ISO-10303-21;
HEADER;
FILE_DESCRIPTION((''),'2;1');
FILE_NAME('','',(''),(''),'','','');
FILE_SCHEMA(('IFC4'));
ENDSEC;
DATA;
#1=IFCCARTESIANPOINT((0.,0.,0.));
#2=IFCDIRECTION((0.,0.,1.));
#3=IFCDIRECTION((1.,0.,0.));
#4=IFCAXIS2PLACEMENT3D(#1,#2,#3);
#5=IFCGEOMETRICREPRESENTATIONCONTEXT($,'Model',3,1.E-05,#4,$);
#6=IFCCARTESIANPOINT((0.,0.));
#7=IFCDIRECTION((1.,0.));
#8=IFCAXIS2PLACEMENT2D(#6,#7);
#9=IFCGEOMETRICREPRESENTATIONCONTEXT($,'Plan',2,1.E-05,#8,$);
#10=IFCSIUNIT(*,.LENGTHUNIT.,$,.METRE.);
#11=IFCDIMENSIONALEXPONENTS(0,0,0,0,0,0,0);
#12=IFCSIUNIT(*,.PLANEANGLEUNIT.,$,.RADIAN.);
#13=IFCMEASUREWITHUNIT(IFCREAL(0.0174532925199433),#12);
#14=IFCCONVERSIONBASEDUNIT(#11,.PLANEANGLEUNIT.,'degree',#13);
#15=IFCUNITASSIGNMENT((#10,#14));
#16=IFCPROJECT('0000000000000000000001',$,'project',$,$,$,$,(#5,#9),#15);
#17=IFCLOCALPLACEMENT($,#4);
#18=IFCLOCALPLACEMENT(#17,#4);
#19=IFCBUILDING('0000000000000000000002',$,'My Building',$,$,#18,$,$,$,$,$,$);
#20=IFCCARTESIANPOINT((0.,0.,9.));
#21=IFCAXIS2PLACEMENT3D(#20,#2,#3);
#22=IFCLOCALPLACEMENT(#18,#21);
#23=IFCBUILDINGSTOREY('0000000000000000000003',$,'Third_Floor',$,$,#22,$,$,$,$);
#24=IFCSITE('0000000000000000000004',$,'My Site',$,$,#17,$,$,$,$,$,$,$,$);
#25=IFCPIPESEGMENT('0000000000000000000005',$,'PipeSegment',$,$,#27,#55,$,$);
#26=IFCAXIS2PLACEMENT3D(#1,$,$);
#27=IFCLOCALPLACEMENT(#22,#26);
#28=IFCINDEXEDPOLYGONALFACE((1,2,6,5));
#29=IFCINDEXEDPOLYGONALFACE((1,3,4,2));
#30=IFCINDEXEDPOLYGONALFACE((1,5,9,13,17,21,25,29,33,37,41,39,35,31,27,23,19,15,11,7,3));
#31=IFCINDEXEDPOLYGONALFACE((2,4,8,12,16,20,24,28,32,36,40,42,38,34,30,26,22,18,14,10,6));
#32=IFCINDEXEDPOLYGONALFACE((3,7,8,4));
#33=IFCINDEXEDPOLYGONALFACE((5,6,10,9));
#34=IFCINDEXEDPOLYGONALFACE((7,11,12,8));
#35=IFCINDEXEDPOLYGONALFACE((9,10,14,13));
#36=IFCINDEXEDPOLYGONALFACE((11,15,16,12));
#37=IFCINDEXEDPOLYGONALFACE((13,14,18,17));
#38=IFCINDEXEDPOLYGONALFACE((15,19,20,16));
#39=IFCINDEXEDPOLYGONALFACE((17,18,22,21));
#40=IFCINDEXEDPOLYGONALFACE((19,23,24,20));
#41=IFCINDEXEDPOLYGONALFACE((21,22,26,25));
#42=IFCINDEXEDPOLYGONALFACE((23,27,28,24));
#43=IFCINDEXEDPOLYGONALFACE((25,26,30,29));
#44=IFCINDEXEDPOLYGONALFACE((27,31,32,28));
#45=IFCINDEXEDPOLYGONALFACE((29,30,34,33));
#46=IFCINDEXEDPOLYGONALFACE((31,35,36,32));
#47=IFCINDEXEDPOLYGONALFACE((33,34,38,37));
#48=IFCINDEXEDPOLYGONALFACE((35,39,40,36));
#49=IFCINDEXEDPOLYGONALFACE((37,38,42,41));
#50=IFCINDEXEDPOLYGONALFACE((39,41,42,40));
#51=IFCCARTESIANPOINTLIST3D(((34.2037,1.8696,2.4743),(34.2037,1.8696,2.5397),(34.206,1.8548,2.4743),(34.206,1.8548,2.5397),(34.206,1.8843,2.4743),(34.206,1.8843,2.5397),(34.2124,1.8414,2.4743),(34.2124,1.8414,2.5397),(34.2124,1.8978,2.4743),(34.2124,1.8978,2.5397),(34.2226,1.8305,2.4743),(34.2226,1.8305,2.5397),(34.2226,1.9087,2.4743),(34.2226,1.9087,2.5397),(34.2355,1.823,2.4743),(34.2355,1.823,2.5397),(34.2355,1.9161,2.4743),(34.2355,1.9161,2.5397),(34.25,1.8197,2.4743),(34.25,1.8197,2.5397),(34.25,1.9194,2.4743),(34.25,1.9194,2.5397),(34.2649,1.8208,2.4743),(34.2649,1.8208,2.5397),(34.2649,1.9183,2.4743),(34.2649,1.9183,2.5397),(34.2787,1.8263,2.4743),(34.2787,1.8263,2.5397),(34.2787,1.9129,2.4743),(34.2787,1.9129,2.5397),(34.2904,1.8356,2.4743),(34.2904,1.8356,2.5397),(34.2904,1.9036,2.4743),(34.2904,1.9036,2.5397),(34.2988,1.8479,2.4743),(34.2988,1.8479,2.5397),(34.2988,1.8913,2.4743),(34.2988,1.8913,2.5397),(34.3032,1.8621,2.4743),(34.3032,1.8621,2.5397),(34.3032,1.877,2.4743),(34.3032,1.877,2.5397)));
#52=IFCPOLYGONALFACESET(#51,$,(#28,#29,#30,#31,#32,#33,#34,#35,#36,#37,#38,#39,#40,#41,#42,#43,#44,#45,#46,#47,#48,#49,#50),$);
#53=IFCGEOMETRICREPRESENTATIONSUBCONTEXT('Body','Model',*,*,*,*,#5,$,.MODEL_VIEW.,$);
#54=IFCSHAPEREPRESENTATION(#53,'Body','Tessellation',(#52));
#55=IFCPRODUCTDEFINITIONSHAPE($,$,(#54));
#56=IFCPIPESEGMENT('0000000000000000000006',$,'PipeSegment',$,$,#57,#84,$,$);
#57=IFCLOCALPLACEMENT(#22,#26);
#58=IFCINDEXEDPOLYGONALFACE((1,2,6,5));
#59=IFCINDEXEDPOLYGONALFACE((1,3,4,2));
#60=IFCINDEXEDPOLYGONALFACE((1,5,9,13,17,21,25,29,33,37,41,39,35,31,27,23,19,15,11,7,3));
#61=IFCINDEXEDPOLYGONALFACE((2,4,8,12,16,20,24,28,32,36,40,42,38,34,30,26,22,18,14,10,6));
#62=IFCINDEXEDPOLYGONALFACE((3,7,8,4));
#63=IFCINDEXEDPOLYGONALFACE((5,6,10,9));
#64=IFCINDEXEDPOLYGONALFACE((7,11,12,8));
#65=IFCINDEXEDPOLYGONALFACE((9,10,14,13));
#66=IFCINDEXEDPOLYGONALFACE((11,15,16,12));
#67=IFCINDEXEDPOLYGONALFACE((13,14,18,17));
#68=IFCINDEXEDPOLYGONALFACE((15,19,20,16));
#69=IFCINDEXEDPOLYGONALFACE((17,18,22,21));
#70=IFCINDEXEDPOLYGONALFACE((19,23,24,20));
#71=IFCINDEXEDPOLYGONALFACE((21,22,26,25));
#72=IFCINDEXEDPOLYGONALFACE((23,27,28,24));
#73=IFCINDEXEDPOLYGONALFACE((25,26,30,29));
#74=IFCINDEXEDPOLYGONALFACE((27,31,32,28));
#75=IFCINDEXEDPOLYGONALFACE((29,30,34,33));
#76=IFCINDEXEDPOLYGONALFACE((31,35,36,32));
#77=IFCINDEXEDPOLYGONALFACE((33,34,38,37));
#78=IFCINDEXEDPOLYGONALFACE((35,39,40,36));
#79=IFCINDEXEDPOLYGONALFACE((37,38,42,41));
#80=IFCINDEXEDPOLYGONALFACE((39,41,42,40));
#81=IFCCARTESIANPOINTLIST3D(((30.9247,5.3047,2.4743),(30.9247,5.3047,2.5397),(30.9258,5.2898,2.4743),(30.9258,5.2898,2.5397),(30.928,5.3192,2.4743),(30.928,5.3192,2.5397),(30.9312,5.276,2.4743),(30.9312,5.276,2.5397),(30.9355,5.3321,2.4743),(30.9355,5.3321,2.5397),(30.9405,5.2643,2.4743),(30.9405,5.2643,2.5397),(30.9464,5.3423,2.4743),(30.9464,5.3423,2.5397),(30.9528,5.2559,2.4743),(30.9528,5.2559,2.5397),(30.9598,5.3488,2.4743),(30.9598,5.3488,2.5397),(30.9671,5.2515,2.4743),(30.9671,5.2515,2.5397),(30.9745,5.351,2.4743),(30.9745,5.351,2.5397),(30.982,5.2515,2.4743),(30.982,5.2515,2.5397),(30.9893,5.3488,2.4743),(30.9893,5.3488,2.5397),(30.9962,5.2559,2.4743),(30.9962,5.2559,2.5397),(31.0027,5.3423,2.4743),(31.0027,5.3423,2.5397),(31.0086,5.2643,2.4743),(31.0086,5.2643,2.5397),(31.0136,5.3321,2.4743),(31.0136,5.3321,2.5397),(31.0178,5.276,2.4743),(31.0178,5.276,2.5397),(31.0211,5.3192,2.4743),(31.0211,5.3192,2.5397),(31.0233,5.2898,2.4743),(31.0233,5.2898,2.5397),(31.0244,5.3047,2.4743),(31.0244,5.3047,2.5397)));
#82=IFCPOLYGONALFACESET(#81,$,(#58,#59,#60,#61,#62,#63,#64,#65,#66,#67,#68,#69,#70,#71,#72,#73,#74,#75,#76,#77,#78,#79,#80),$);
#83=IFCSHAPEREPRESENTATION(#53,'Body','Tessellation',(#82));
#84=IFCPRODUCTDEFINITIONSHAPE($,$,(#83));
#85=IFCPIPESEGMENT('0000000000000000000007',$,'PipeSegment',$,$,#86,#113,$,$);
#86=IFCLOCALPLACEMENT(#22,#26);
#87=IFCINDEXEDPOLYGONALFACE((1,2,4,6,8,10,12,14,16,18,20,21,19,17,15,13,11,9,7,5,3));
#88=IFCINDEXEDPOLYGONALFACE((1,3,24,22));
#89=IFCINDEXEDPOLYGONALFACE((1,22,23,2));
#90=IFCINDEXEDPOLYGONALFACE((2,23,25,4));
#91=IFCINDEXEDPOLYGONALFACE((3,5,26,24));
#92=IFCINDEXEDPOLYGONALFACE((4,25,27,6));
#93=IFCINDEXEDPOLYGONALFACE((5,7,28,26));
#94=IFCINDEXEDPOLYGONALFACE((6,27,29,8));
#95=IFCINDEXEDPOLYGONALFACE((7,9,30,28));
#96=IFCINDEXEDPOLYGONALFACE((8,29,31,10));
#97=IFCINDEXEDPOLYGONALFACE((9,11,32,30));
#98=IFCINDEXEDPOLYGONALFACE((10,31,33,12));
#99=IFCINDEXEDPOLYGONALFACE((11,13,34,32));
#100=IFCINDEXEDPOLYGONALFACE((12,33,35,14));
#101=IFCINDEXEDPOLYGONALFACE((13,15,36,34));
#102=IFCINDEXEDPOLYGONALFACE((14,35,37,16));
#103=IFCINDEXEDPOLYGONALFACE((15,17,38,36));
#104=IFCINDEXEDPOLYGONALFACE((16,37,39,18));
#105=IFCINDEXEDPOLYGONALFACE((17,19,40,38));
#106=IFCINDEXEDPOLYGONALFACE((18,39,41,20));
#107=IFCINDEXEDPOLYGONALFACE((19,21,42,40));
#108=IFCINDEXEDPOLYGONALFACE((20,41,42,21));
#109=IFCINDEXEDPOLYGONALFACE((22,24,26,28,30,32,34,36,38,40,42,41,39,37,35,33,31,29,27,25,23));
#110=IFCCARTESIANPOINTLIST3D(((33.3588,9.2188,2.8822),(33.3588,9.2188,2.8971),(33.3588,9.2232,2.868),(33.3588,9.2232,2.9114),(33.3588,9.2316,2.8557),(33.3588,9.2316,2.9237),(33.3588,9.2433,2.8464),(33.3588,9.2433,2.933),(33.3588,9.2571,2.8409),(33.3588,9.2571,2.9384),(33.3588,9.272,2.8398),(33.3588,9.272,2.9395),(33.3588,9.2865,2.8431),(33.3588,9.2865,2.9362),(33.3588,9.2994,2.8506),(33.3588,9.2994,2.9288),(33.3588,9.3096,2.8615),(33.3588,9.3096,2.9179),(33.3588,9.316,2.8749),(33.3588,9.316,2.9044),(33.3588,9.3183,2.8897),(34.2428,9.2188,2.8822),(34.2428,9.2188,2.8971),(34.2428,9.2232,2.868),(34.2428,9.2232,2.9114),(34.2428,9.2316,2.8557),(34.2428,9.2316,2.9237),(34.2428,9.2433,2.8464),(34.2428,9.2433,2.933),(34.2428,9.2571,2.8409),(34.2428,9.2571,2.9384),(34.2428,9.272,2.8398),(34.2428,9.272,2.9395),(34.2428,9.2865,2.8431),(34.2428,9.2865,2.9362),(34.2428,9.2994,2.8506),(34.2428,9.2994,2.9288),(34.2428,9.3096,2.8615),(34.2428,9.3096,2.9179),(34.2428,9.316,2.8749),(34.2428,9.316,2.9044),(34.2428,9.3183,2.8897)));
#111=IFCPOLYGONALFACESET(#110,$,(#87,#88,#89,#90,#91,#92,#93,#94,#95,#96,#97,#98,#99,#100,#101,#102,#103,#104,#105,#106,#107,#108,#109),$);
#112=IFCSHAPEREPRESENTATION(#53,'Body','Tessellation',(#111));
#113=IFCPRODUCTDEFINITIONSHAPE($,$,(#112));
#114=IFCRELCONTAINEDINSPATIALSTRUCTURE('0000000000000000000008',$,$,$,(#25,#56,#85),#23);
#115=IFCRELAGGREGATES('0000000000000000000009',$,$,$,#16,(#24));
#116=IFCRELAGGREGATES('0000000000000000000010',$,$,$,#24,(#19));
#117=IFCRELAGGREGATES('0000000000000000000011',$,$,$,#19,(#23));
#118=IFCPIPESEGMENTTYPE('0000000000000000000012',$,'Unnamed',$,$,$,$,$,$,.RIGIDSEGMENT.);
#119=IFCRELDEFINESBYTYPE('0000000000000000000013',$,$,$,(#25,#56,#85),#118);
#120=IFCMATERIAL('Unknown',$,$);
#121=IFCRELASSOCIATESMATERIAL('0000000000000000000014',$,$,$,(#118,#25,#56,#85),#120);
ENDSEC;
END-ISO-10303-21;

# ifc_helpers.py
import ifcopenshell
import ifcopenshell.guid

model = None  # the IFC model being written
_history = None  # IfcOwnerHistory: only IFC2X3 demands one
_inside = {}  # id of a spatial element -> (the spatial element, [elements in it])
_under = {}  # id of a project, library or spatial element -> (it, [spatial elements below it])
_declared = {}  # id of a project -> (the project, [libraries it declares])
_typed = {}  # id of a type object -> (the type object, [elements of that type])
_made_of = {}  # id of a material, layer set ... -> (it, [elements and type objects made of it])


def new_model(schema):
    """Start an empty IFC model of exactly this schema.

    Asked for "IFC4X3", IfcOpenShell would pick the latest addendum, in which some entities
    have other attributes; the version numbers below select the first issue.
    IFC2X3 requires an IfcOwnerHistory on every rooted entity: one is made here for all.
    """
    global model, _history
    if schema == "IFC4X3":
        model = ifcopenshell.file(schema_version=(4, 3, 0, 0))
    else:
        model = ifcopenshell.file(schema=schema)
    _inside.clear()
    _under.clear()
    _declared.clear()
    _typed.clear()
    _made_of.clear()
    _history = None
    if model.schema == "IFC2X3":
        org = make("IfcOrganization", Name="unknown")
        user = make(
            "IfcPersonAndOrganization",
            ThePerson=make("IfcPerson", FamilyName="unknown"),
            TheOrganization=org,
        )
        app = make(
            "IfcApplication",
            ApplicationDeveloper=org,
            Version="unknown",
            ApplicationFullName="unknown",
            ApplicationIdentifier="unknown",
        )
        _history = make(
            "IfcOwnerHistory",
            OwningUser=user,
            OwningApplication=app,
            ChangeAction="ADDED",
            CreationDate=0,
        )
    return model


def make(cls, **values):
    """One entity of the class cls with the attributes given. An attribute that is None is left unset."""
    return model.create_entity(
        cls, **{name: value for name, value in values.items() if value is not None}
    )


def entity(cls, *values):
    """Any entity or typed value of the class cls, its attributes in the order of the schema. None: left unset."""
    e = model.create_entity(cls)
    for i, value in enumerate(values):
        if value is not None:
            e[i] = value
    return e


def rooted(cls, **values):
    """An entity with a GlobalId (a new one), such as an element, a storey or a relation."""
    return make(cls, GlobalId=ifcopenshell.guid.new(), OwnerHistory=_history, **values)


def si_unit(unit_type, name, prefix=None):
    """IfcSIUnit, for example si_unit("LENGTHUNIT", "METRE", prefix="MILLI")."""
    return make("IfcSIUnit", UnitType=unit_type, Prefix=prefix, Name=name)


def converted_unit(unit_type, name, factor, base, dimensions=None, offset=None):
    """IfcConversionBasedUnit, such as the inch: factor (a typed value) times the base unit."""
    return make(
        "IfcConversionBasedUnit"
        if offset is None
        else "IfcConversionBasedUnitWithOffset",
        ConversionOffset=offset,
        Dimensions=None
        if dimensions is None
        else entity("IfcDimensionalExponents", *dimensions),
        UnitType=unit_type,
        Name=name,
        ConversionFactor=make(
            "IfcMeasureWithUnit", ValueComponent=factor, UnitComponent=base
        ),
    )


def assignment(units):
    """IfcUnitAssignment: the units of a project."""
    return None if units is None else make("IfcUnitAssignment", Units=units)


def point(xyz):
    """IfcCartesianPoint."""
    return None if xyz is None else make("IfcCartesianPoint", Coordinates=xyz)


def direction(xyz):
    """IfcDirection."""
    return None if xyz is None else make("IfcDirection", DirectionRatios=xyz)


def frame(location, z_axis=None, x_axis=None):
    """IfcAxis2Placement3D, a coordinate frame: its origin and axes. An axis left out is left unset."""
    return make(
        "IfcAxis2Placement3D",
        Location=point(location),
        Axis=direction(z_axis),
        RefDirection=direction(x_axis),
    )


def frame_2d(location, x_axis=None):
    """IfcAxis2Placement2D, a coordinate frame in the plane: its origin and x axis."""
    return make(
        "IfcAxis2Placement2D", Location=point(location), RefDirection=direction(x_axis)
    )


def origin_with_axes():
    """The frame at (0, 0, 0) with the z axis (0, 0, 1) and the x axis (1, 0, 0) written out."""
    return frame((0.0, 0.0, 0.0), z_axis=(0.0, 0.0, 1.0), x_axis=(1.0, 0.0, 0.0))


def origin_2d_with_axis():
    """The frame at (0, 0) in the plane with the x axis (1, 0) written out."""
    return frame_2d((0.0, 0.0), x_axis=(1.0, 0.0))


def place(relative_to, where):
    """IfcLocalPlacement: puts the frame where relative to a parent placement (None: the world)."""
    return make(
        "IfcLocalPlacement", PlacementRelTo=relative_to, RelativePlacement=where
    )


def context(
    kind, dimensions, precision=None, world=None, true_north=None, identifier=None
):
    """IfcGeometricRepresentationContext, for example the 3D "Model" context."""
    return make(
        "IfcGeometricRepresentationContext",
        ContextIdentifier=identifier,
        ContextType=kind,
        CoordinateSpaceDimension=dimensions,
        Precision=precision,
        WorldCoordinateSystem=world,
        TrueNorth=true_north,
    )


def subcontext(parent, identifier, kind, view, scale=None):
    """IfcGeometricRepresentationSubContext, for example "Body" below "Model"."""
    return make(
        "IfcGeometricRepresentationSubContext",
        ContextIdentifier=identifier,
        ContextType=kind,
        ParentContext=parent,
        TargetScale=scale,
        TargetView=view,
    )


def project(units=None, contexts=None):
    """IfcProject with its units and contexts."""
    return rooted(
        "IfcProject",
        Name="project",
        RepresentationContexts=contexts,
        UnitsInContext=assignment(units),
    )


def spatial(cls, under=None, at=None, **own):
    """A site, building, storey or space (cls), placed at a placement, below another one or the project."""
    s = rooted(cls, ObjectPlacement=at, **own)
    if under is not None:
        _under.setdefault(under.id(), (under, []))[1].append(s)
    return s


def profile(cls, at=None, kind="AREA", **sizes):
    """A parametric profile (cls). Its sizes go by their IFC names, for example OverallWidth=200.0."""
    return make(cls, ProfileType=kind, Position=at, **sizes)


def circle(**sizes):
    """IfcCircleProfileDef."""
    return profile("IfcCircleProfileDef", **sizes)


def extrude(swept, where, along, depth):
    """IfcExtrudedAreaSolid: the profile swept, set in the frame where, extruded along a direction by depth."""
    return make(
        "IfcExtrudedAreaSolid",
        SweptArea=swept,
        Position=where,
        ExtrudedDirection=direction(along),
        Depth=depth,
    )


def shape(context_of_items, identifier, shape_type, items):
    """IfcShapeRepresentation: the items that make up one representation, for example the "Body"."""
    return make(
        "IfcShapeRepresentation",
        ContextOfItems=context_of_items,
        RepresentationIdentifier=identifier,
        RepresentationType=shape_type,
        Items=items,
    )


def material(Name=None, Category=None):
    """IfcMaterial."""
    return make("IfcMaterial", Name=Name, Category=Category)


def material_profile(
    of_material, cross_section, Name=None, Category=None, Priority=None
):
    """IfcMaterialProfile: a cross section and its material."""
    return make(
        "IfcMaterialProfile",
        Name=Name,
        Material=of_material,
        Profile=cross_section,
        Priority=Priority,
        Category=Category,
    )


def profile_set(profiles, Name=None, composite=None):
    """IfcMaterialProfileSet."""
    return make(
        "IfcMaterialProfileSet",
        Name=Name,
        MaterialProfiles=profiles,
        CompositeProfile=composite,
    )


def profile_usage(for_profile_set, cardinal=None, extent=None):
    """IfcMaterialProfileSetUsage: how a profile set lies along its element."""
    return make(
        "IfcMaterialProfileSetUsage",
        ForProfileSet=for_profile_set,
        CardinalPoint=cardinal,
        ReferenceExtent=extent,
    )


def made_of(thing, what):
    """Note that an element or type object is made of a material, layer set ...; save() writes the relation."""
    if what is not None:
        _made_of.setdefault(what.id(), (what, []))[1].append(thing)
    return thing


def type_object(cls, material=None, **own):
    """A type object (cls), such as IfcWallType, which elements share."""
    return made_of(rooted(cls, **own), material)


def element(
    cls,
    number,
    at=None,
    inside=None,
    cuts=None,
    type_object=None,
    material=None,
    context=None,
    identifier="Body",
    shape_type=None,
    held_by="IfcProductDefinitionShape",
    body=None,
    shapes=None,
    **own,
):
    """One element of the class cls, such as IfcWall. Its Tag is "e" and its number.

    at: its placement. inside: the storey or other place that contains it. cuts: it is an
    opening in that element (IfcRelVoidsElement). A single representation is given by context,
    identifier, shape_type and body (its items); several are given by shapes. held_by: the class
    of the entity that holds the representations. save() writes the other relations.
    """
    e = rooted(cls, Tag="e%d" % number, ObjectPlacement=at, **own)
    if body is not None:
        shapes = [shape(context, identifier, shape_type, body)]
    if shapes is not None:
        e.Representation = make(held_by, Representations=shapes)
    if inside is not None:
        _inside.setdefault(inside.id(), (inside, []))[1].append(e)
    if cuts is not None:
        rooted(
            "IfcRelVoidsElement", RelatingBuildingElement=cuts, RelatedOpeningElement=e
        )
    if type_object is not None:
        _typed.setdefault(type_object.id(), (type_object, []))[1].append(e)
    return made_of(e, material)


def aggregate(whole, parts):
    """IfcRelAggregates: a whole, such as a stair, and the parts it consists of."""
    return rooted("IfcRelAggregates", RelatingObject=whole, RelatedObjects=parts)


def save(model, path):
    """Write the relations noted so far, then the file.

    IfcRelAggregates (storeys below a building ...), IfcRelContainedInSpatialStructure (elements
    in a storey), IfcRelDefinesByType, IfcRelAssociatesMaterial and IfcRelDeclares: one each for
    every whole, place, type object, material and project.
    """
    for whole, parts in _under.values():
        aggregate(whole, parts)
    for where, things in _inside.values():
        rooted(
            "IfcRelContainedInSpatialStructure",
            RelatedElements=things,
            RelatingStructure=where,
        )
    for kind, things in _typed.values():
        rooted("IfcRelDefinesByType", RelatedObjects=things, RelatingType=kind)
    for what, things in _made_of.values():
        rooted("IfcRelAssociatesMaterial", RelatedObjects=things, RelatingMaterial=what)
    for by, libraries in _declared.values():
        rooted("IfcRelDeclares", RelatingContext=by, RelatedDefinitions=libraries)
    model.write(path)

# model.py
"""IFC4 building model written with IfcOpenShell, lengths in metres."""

from ifc_helpers import new_model, entity, si_unit, converted_unit, frame, origin_with_axes, origin_2d_with_axis, place, context, subcontext, project, spatial, circle, extrude, material, material_profile, profile_set, profile_usage, type_object, element, save


model = new_model("IFC4")

# Units and contexts
model_context = context("Model", 3, precision=1e-05, world=origin_with_axes())
plan_context = context("Plan", 2, precision=1e-05, world=origin_2d_with_axis())
body_context_1 = subcontext(model_context, "Body", "Model", "MODEL_VIEW")
ifc_project = project(units=[si_unit("LENGTHUNIT", "METRE"), converted_unit("PLANEANGLEUNIT", "degree", entity("IfcReal", 0.0174532925199433), si_unit("PLANEANGLEUNIT", "RADIAN"), dimensions=[0, 0, 0, 0, 0, 0, 0])], contexts=[model_context, plan_context])

# Site, building, storey
site_placement = place(None, origin_with_axes())
site = spatial("IfcSite", under=ifc_project, at=site_placement, Name="My Site")
building_placement = place(site_placement, origin_with_axes())
building = spatial("IfcBuilding", under=site, at=building_placement, Name="My Building")
storey_placement = place(building_placement, frame((0.0, 0.0, 9.0), z_axis=(0.0, 0.0, 1.0), x_axis=(1.0, 0.0, 0.0)))
storey = spatial("IfcBuildingStorey", under=building, at=storey_placement, Name="Third_Floor")

# Shared definitions
ifc_material = material(Name="Unknown")

# Pipe segments
ifc_material_profile_1 = material_profile(ifc_material, circle(Radius=0.05))
ifc_profile_set_1 = profile_set([ifc_material_profile_1])
pipe_segment_type = type_object("IfcPipeSegmentType", Name="Unnamed", PredefinedType="RIGIDSEGMENT", material=ifc_profile_set_1)
ifc_profile_usage_1 = profile_usage(ifc_profile_set_1, cardinal=5)
pipe_segment_1_placement = place(storey_placement, frame((34.2537, 1.8696, 2.4743), z_axis=(0.0, 0.0, 1.0), x_axis=(-1.0, 0.0, 0.0)))
element("IfcPipeSegment", 1, at=pipe_segment_1_placement, inside=storey, type_object=pipe_segment_type, material=ifc_profile_usage_1, Name="PipeSegment", context=body_context_1, shape_type="SweptSolid", body=[
    extrude(circle(Radius=0.05), origin_with_axes(), (0.0, 0.0, 1.0), 0.0654),
])
ifc_profile_usage_2 = profile_usage(ifc_profile_set_1, cardinal=5)
pipe_segment_2_placement = place(storey_placement, frame((30.9745, 5.301, 2.4743), z_axis=(0.0, 0.0, 1.0), x_axis=(-0.000001, 1.0, 0.0)))
element("IfcPipeSegment", 2, at=pipe_segment_2_placement, inside=storey, type_object=pipe_segment_type, material=ifc_profile_usage_2, Name="PipeSegment", context=body_context_1, shape_type="SweptSolid", body=[
    extrude(circle(Radius=0.05), origin_with_axes(), (0.0, 0.0, 1.0), 0.0654),
])
ifc_profile_usage_3 = profile_usage(ifc_profile_set_1, cardinal=5)
pipe_segment_3_placement = place(storey_placement, frame((33.3588, 9.2683, 2.8897), z_axis=(1.0, 0.0, 0.0), x_axis=(0.0, 1.0, 0.0)))
element("IfcPipeSegment", 3, at=pipe_segment_3_placement, inside=storey, type_object=pipe_segment_type, material=ifc_profile_usage_3, Name="PipeSegment", context=body_context_1, shape_type="SweptSolid", body=[
    extrude(circle(Radius=0.05), origin_with_axes(), (0.0, 0.0, 1.0), 0.884),
])

save(model, "model.ifc")
